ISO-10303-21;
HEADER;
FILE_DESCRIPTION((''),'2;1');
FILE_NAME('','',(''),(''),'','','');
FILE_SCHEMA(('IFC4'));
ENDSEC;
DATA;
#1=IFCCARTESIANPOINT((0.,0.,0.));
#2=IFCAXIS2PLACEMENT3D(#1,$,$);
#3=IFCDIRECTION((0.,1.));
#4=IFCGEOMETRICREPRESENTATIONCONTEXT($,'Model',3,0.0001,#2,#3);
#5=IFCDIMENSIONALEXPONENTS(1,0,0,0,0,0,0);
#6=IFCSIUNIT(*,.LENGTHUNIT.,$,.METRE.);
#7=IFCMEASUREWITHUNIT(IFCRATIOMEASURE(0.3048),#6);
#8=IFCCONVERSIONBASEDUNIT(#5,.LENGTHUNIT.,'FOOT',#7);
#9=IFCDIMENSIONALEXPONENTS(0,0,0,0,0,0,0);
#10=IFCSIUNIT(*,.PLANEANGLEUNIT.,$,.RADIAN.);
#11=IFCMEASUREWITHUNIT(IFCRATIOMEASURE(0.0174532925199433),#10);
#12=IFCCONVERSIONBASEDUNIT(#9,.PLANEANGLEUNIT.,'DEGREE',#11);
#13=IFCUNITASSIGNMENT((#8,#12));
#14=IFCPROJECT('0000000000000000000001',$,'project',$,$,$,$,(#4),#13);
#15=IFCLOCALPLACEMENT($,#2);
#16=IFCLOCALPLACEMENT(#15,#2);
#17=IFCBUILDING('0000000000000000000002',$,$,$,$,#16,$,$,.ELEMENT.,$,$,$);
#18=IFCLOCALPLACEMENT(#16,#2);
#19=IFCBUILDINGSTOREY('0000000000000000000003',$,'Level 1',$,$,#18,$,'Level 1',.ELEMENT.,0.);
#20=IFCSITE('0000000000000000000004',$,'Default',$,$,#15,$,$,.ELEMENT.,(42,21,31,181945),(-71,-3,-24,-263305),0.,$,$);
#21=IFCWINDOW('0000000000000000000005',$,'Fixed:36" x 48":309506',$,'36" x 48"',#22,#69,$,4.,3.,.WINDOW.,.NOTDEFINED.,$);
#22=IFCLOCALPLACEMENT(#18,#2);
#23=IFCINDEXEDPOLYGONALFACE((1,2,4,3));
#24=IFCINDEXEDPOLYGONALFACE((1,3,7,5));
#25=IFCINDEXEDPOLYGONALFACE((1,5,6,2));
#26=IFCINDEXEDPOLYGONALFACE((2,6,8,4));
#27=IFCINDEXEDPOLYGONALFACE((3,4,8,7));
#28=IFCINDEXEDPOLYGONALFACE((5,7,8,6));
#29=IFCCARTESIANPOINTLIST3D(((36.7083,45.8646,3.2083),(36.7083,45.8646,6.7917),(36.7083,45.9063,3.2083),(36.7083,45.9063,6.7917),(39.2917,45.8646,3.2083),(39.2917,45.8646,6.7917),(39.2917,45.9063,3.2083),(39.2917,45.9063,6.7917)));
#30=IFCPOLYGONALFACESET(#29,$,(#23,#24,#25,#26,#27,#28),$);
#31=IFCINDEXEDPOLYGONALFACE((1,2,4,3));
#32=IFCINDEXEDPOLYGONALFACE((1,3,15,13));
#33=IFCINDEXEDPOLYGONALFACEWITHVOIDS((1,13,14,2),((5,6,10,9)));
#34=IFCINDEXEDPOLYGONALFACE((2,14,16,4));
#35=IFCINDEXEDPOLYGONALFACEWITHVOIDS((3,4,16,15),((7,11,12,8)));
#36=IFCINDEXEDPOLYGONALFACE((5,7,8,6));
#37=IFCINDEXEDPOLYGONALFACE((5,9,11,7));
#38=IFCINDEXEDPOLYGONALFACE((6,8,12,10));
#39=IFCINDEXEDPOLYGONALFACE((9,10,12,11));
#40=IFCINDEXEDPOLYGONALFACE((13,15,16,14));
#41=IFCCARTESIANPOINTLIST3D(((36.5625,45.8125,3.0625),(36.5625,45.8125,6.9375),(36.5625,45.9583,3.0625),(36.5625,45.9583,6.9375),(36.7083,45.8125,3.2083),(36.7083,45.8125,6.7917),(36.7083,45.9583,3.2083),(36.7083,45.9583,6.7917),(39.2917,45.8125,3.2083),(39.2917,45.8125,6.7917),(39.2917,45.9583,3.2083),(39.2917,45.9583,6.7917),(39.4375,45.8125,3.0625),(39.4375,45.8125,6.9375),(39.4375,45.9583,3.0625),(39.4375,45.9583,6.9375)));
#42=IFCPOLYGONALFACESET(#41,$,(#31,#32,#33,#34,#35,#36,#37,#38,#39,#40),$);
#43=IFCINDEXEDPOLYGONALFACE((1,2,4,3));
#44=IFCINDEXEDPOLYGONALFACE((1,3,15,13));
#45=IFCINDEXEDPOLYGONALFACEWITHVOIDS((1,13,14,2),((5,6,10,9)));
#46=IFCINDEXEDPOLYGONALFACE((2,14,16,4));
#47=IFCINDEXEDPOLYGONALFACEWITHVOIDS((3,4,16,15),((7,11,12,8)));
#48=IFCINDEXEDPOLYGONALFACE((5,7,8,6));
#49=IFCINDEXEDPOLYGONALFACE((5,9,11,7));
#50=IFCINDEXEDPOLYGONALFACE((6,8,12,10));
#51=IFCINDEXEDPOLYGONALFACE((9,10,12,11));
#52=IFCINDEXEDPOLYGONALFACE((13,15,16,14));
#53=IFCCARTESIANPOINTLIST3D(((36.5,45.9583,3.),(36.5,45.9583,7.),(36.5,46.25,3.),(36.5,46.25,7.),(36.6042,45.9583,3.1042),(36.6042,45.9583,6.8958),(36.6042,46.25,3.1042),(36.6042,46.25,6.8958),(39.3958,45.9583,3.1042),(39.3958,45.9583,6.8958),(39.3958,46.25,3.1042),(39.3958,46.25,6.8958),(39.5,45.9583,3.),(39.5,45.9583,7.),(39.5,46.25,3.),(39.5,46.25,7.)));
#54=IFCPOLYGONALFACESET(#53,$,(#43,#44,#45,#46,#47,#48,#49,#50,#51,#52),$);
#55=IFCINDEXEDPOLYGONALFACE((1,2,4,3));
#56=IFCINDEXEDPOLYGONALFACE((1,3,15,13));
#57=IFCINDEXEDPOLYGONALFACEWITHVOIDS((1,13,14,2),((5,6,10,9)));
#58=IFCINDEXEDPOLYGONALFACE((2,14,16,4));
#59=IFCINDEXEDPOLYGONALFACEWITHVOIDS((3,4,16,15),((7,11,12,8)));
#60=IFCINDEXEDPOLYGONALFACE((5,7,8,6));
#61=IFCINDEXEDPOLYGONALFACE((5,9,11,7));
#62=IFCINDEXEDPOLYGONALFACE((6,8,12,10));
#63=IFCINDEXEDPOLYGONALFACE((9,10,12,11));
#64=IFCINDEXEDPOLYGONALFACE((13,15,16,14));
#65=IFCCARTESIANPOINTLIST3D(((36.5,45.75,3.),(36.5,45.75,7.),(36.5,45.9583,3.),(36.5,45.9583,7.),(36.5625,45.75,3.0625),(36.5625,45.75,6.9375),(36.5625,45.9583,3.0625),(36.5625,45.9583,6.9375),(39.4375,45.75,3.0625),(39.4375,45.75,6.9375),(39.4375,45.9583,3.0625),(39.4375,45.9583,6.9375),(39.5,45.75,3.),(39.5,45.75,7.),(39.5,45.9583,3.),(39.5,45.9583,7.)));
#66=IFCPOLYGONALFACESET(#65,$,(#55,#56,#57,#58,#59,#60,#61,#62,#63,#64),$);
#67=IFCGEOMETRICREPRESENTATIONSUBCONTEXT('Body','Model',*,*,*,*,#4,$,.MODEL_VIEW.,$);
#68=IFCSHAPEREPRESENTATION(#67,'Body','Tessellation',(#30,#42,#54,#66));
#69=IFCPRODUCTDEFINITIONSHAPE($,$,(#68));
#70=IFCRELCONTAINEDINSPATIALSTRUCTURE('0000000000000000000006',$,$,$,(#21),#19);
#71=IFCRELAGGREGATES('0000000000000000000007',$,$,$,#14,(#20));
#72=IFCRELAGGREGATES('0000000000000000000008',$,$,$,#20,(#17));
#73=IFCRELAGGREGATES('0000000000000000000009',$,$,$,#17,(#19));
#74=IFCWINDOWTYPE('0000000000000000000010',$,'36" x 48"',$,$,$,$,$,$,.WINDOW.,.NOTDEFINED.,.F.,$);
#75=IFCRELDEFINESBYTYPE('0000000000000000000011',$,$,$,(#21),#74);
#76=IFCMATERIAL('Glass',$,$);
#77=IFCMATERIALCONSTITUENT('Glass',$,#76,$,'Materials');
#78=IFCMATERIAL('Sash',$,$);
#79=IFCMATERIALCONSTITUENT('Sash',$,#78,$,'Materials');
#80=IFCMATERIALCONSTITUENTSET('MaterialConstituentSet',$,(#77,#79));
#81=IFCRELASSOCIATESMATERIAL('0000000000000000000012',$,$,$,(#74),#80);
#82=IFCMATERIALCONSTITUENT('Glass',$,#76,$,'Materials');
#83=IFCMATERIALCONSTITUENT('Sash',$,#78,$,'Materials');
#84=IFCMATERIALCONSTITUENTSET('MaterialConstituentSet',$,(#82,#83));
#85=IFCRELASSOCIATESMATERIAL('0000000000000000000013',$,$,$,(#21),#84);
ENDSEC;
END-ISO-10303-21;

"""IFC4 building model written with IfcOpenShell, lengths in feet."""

from ifc_helpers import new_model, entity, si_unit, converted_unit, direction, frame, frame_2d, origin, place, context, subcontext, project, spatial, polyline, rectangle, outline, extrude, source, transform, mapped, material, constituent, constituent_set, type_object, type_shapes, element, save


model = new_model("IFC4")

# Units and contexts
model_context = context("Model", 3, precision=0.0001, world=origin(), true_north=direction((0.0, 1.0)))
body_context = subcontext(model_context, "Body", "Model", "MODEL_VIEW")
ifc_project = project(units=[converted_unit("LENGTHUNIT", "FOOT", entity("IfcRatioMeasure", 0.3048), si_unit("LENGTHUNIT", "METRE"), dimensions=[1, 0, 0, 0, 0, 0, 0]), converted_unit("PLANEANGLEUNIT", "DEGREE", entity("IfcRatioMeasure", 0.0174532925199433), si_unit("PLANEANGLEUNIT", "RADIAN"), dimensions=[0, 0, 0, 0, 0, 0, 0])], contexts=[model_context])

# Site, building, storey
site_placement = place(None, origin())
site = spatial("IfcSite", under=ifc_project, at=site_placement, Name="Default", CompositionType="ELEMENT", RefLatitude=(42, 21, 31, 181945), RefLongitude=(-71, -3, -24, -263305), RefElevation=0.0)
building_placement = place(site_placement, origin())
building = spatial("IfcBuilding", under=site, at=building_placement, CompositionType="ELEMENT")
storey_placement = place(building_placement, origin())
storey = spatial("IfcBuildingStorey", under=building, at=storey_placement, Name="Level 1", LongName="Level 1", CompositionType="ELEMENT", Elevation=0.0)

# Shared definitions
placement_1 = place(storey_placement, frame((-0.25, 46.0, 0.0)))

# Window
ifc_material_1 = material(Name="Glass")
ifc_constituent_1 = constituent(ifc_material_1, Name="Glass", Category="Materials")
ifc_material_2 = material(Name="Sash")
ifc_constituent_2 = constituent(ifc_material_2, Name="Sash", Category="Materials")
ifc_constituent_set_1 = constituent_set(constituents=[ifc_constituent_1, ifc_constituent_2], Name="MaterialConstituentSet")
ifc_constituent_3 = constituent(ifc_material_1, Name="Glass", Category="Materials")
ifc_constituent_4 = constituent(ifc_material_2, Name="Sash", Category="Materials")
ifc_constituent_set_2 = constituent_set(constituents=[ifc_constituent_3, ifc_constituent_4], Name="MaterialConstituentSet")
window_type = type_object("IfcWindowType", Name="36\" x 48\"", ParameterTakesPrecedence=False, PartitioningType="NOTDEFINED", PredefinedType="WINDOW", material=ifc_constituent_set_2)
shared_shape = source(origin(), body_context, "Body", "SweptSolid", [
    extrude(rectangle(XDim=0.0417, YDim=2.5833, at=frame_2d((0.0, 0.0), x_axis=(1.0, 0.0))), frame((1.5, 0.3646, 0.2083), z_axis=(0.0, 0.0, 1.0), x_axis=(0.0, 1.0, 0.0)), (0.0, 0.0, 1.0), 3.5833),
    extrude(outline(polyline([(-1.4375, -1.9375), (1.4375, -1.9375), (1.4375, 1.9375), (-1.4375, 1.9375), (-1.4375, -1.9375)]), holes=[polyline([(-1.2917, -1.7917), (-1.2917, 1.7917), (1.2917, 1.7917), (1.2917, -1.7917), (-1.2917, -1.7917)])]), frame((1.5, 0.2917, 2.0), z_axis=(0.0, 1.0, 0.0), x_axis=(1.0, 0.0, 0.0)), (0.0, 0.0, 1.0), 0.1458),
    extrude(outline(polyline([(-1.5, -2.0), (1.5, -2.0), (1.5, 2.0), (-1.5, 2.0), (-1.5, -2.0)]), holes=[polyline([(-1.3958, -1.8958), (-1.3958, 1.8958), (1.3958, 1.8958), (1.3958, -1.8958), (-1.3958, -1.8958)])]), frame((1.5, 0.0, 2.0), z_axis=(0.0, 1.0, 0.0), x_axis=(1.0, 0.0, 0.0)), (0.0, 0.0, 1.0), 0.2917),
    extrude(outline(polyline([(-2.0, -1.5), (2.0, -1.5), (2.0, 1.5), (-2.0, 1.5), (-2.0, -1.5)]), holes=[polyline([(-1.9375, -1.4375), (-1.9375, 1.4375), (1.9375, 1.4375), (1.9375, -1.4375), (-1.9375, -1.4375)])]), frame((1.5, 0.2917, 2.0), z_axis=(0.0, 1.0, 0.0), x_axis=(0.0, 0.0, -1.0)), (0.0, 0.0, 1.0), 0.2083),
])
type_shapes(window_type, [shared_shape])
placement_2 = place(placement_1, frame((39.75, 0.25, 3.0)))
window_placement = place(placement_2, frame((0.0, 0.0, 0.0), z_axis=(0.0, 0.0, 1.0), x_axis=(-1.0, 0.0, 0.0)))
element("IfcWindow", 1, at=window_placement, inside=storey, type_object=window_type, material=ifc_constituent_set_1, Name="Fixed:36\" x 48\":309506", ObjectType="36\" x 48\"", OverallHeight=4.0, OverallWidth=3.0, PartitioningType="NOTDEFINED", PredefinedType="WINDOW", context=body_context, shape_type="MappedRepresentation", body=[
    mapped(shared_shape, transform((0.0, 0.0, 0.0), scale=1.0)),
])

save(model, "model.ifc")
